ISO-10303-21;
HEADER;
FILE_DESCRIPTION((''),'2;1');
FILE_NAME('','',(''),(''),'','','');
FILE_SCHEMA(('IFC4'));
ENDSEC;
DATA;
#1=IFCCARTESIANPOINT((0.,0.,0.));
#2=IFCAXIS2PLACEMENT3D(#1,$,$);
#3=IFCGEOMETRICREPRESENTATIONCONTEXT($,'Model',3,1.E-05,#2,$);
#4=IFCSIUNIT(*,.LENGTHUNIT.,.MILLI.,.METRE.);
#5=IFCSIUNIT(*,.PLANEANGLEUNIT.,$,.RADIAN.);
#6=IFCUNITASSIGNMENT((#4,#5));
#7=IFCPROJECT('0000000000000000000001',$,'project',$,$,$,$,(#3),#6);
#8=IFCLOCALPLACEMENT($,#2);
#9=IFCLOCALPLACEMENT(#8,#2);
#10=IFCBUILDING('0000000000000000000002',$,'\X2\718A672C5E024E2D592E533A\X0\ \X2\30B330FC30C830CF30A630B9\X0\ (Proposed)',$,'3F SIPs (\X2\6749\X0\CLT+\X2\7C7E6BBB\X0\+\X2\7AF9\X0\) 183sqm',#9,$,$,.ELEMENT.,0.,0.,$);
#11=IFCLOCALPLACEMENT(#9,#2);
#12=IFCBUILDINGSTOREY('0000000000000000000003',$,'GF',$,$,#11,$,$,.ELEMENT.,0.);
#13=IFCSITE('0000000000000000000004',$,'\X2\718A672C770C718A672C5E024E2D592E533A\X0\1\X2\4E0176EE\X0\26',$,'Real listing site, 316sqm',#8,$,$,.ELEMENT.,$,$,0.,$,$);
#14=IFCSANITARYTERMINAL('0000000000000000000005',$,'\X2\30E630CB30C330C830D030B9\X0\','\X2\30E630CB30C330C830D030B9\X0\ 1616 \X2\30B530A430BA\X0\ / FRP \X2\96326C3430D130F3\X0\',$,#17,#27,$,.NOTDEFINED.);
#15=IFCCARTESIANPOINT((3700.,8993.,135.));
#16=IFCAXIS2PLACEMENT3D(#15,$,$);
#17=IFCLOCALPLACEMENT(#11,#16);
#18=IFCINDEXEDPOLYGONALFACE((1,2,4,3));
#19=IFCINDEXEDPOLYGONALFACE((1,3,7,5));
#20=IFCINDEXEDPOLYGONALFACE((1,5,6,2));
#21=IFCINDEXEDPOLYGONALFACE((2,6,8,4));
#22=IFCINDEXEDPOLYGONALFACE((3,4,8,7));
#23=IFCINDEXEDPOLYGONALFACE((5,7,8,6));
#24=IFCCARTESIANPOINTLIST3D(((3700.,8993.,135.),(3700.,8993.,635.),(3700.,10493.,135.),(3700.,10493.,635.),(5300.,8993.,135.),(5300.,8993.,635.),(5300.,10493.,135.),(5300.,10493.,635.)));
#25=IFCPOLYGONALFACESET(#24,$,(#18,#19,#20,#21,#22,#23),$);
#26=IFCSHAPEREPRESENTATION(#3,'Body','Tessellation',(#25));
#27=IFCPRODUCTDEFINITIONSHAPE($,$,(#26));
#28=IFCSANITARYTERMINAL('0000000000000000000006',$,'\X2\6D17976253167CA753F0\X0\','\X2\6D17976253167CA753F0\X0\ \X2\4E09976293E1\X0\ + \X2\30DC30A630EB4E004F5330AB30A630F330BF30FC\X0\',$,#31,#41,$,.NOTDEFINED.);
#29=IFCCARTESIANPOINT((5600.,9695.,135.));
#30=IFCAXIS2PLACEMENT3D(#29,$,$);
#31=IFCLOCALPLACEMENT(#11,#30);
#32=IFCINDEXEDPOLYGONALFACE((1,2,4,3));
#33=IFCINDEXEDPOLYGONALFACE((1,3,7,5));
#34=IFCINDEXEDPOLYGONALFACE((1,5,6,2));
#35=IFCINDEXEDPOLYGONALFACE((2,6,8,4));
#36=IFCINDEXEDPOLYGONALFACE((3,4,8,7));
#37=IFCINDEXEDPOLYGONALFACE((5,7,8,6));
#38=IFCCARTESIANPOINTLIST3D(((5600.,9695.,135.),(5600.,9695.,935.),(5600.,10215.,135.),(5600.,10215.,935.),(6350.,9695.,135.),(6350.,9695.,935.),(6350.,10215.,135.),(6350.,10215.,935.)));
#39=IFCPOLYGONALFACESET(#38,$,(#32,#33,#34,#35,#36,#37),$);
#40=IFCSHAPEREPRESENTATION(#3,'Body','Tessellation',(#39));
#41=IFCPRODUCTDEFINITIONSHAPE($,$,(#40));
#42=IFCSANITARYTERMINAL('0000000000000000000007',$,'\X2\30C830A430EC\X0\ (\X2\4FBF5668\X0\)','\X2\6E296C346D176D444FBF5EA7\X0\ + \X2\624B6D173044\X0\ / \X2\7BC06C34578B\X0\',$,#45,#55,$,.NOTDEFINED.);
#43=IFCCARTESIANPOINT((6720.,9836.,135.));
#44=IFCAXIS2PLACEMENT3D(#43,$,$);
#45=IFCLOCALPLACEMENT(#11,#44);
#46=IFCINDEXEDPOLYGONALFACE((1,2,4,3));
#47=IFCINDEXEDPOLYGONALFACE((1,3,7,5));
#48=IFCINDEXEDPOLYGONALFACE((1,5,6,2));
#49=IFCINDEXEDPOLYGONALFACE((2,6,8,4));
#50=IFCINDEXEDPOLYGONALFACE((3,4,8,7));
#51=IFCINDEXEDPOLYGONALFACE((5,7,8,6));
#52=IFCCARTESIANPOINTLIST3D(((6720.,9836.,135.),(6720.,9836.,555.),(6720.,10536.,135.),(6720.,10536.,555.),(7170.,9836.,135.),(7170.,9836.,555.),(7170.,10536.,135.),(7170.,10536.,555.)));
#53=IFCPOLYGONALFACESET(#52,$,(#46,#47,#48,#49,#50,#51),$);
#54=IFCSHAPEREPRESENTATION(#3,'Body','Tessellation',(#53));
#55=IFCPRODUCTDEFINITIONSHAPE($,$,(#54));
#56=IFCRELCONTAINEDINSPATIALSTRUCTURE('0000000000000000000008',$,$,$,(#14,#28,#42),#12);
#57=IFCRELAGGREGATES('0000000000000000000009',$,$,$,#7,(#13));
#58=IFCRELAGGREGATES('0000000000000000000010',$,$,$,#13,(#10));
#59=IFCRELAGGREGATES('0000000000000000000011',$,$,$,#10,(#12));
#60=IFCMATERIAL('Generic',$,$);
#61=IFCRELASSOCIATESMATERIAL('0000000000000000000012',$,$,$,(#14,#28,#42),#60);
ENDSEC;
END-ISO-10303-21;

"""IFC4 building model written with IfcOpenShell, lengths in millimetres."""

from ifc_helpers import new_model, si_unit, frame, frame_2d, origin, place, context, project, spatial, rectangle, extrude, material, element, save


model = new_model("IFC4")

# Units and contexts
model_context = context("Model", 3, precision=1e-05, world=origin())
ifc_project = project(units=[si_unit("LENGTHUNIT", "METRE", prefix="MILLI"), si_unit("PLANEANGLEUNIT", "RADIAN")], contexts=[model_context])

# Site, building, storey
site_placement = place(None, origin())
site = spatial("IfcSite", under=ifc_project, at=site_placement, Name="熊本県熊本市中央区1丁目26", ObjectType="Real listing site, 316sqm", CompositionType="ELEMENT", RefElevation=0.0)
building_placement = place(site_placement, origin())
building = spatial("IfcBuilding", under=site, at=building_placement, Name="熊本市中央区 コートハウス (Proposed)", ObjectType="3F SIPs (杉CLT+籾殻+竹) 183sqm", CompositionType="ELEMENT", ElevationOfRefHeight=0.0, ElevationOfTerrain=0.0)
storey_placement = place(building_placement, origin())
storey = spatial("IfcBuildingStorey", under=building, at=storey_placement, Name="GF", CompositionType="ELEMENT", Elevation=0.0)

# Shared definitions
ifc_material_1 = material(Name="Generic")

# Sanitary terminals
sanitary_terminal_1_placement = place(storey_placement, frame((3700.0, 8993.0, 135.0)))
element("IfcSanitaryTerminal", 1, at=sanitary_terminal_1_placement, inside=storey, material=ifc_material_1, Name="ユニットバス", Description="ユニットバス 1616 サイズ / FRP 防水パン", PredefinedType="NOTDEFINED", context=model_context, shape_type="SweptSolid", body=[
    extrude(rectangle(XDim=1600.0, YDim=1500.0, at=frame_2d((800.0, 750.0))), frame((3700.0, 8993.0, 135.0)), (0.0, 0.0, 1.0), 500.0),
])
sanitary_terminal_2_placement = place(storey_placement, frame((5600.0, 9695.0, 135.0)))
element("IfcSanitaryTerminal", 2, at=sanitary_terminal_2_placement, inside=storey, material=ifc_material_1, Name="洗面化粧台", Description="洗面化粧台 三面鏡 + ボウル一体カウンター", PredefinedType="NOTDEFINED", context=model_context, shape_type="SweptSolid", body=[
    extrude(rectangle(XDim=750.0, YDim=520.0, at=frame_2d((375.0, 260.0))), frame((5600.0, 9695.0, 135.0)), (0.0, 0.0, 1.0), 800.0),
])
sanitary_terminal_3_placement = place(storey_placement, frame((6720.0, 9836.0, 135.0)))
element("IfcSanitaryTerminal", 3, at=sanitary_terminal_3_placement, inside=storey, material=ifc_material_1, Name="トイレ (便器)", Description="温水洗浄便座 + 手洗い / 節水型", PredefinedType="NOTDEFINED", context=model_context, shape_type="SweptSolid", body=[
    extrude(rectangle(XDim=450.0, YDim=700.0, at=frame_2d((225.0, 350.0))), frame((6720.0, 9836.0, 135.0)), (0.0, 0.0, 1.0), 420.0),
])

save(model, "model.ifc")
